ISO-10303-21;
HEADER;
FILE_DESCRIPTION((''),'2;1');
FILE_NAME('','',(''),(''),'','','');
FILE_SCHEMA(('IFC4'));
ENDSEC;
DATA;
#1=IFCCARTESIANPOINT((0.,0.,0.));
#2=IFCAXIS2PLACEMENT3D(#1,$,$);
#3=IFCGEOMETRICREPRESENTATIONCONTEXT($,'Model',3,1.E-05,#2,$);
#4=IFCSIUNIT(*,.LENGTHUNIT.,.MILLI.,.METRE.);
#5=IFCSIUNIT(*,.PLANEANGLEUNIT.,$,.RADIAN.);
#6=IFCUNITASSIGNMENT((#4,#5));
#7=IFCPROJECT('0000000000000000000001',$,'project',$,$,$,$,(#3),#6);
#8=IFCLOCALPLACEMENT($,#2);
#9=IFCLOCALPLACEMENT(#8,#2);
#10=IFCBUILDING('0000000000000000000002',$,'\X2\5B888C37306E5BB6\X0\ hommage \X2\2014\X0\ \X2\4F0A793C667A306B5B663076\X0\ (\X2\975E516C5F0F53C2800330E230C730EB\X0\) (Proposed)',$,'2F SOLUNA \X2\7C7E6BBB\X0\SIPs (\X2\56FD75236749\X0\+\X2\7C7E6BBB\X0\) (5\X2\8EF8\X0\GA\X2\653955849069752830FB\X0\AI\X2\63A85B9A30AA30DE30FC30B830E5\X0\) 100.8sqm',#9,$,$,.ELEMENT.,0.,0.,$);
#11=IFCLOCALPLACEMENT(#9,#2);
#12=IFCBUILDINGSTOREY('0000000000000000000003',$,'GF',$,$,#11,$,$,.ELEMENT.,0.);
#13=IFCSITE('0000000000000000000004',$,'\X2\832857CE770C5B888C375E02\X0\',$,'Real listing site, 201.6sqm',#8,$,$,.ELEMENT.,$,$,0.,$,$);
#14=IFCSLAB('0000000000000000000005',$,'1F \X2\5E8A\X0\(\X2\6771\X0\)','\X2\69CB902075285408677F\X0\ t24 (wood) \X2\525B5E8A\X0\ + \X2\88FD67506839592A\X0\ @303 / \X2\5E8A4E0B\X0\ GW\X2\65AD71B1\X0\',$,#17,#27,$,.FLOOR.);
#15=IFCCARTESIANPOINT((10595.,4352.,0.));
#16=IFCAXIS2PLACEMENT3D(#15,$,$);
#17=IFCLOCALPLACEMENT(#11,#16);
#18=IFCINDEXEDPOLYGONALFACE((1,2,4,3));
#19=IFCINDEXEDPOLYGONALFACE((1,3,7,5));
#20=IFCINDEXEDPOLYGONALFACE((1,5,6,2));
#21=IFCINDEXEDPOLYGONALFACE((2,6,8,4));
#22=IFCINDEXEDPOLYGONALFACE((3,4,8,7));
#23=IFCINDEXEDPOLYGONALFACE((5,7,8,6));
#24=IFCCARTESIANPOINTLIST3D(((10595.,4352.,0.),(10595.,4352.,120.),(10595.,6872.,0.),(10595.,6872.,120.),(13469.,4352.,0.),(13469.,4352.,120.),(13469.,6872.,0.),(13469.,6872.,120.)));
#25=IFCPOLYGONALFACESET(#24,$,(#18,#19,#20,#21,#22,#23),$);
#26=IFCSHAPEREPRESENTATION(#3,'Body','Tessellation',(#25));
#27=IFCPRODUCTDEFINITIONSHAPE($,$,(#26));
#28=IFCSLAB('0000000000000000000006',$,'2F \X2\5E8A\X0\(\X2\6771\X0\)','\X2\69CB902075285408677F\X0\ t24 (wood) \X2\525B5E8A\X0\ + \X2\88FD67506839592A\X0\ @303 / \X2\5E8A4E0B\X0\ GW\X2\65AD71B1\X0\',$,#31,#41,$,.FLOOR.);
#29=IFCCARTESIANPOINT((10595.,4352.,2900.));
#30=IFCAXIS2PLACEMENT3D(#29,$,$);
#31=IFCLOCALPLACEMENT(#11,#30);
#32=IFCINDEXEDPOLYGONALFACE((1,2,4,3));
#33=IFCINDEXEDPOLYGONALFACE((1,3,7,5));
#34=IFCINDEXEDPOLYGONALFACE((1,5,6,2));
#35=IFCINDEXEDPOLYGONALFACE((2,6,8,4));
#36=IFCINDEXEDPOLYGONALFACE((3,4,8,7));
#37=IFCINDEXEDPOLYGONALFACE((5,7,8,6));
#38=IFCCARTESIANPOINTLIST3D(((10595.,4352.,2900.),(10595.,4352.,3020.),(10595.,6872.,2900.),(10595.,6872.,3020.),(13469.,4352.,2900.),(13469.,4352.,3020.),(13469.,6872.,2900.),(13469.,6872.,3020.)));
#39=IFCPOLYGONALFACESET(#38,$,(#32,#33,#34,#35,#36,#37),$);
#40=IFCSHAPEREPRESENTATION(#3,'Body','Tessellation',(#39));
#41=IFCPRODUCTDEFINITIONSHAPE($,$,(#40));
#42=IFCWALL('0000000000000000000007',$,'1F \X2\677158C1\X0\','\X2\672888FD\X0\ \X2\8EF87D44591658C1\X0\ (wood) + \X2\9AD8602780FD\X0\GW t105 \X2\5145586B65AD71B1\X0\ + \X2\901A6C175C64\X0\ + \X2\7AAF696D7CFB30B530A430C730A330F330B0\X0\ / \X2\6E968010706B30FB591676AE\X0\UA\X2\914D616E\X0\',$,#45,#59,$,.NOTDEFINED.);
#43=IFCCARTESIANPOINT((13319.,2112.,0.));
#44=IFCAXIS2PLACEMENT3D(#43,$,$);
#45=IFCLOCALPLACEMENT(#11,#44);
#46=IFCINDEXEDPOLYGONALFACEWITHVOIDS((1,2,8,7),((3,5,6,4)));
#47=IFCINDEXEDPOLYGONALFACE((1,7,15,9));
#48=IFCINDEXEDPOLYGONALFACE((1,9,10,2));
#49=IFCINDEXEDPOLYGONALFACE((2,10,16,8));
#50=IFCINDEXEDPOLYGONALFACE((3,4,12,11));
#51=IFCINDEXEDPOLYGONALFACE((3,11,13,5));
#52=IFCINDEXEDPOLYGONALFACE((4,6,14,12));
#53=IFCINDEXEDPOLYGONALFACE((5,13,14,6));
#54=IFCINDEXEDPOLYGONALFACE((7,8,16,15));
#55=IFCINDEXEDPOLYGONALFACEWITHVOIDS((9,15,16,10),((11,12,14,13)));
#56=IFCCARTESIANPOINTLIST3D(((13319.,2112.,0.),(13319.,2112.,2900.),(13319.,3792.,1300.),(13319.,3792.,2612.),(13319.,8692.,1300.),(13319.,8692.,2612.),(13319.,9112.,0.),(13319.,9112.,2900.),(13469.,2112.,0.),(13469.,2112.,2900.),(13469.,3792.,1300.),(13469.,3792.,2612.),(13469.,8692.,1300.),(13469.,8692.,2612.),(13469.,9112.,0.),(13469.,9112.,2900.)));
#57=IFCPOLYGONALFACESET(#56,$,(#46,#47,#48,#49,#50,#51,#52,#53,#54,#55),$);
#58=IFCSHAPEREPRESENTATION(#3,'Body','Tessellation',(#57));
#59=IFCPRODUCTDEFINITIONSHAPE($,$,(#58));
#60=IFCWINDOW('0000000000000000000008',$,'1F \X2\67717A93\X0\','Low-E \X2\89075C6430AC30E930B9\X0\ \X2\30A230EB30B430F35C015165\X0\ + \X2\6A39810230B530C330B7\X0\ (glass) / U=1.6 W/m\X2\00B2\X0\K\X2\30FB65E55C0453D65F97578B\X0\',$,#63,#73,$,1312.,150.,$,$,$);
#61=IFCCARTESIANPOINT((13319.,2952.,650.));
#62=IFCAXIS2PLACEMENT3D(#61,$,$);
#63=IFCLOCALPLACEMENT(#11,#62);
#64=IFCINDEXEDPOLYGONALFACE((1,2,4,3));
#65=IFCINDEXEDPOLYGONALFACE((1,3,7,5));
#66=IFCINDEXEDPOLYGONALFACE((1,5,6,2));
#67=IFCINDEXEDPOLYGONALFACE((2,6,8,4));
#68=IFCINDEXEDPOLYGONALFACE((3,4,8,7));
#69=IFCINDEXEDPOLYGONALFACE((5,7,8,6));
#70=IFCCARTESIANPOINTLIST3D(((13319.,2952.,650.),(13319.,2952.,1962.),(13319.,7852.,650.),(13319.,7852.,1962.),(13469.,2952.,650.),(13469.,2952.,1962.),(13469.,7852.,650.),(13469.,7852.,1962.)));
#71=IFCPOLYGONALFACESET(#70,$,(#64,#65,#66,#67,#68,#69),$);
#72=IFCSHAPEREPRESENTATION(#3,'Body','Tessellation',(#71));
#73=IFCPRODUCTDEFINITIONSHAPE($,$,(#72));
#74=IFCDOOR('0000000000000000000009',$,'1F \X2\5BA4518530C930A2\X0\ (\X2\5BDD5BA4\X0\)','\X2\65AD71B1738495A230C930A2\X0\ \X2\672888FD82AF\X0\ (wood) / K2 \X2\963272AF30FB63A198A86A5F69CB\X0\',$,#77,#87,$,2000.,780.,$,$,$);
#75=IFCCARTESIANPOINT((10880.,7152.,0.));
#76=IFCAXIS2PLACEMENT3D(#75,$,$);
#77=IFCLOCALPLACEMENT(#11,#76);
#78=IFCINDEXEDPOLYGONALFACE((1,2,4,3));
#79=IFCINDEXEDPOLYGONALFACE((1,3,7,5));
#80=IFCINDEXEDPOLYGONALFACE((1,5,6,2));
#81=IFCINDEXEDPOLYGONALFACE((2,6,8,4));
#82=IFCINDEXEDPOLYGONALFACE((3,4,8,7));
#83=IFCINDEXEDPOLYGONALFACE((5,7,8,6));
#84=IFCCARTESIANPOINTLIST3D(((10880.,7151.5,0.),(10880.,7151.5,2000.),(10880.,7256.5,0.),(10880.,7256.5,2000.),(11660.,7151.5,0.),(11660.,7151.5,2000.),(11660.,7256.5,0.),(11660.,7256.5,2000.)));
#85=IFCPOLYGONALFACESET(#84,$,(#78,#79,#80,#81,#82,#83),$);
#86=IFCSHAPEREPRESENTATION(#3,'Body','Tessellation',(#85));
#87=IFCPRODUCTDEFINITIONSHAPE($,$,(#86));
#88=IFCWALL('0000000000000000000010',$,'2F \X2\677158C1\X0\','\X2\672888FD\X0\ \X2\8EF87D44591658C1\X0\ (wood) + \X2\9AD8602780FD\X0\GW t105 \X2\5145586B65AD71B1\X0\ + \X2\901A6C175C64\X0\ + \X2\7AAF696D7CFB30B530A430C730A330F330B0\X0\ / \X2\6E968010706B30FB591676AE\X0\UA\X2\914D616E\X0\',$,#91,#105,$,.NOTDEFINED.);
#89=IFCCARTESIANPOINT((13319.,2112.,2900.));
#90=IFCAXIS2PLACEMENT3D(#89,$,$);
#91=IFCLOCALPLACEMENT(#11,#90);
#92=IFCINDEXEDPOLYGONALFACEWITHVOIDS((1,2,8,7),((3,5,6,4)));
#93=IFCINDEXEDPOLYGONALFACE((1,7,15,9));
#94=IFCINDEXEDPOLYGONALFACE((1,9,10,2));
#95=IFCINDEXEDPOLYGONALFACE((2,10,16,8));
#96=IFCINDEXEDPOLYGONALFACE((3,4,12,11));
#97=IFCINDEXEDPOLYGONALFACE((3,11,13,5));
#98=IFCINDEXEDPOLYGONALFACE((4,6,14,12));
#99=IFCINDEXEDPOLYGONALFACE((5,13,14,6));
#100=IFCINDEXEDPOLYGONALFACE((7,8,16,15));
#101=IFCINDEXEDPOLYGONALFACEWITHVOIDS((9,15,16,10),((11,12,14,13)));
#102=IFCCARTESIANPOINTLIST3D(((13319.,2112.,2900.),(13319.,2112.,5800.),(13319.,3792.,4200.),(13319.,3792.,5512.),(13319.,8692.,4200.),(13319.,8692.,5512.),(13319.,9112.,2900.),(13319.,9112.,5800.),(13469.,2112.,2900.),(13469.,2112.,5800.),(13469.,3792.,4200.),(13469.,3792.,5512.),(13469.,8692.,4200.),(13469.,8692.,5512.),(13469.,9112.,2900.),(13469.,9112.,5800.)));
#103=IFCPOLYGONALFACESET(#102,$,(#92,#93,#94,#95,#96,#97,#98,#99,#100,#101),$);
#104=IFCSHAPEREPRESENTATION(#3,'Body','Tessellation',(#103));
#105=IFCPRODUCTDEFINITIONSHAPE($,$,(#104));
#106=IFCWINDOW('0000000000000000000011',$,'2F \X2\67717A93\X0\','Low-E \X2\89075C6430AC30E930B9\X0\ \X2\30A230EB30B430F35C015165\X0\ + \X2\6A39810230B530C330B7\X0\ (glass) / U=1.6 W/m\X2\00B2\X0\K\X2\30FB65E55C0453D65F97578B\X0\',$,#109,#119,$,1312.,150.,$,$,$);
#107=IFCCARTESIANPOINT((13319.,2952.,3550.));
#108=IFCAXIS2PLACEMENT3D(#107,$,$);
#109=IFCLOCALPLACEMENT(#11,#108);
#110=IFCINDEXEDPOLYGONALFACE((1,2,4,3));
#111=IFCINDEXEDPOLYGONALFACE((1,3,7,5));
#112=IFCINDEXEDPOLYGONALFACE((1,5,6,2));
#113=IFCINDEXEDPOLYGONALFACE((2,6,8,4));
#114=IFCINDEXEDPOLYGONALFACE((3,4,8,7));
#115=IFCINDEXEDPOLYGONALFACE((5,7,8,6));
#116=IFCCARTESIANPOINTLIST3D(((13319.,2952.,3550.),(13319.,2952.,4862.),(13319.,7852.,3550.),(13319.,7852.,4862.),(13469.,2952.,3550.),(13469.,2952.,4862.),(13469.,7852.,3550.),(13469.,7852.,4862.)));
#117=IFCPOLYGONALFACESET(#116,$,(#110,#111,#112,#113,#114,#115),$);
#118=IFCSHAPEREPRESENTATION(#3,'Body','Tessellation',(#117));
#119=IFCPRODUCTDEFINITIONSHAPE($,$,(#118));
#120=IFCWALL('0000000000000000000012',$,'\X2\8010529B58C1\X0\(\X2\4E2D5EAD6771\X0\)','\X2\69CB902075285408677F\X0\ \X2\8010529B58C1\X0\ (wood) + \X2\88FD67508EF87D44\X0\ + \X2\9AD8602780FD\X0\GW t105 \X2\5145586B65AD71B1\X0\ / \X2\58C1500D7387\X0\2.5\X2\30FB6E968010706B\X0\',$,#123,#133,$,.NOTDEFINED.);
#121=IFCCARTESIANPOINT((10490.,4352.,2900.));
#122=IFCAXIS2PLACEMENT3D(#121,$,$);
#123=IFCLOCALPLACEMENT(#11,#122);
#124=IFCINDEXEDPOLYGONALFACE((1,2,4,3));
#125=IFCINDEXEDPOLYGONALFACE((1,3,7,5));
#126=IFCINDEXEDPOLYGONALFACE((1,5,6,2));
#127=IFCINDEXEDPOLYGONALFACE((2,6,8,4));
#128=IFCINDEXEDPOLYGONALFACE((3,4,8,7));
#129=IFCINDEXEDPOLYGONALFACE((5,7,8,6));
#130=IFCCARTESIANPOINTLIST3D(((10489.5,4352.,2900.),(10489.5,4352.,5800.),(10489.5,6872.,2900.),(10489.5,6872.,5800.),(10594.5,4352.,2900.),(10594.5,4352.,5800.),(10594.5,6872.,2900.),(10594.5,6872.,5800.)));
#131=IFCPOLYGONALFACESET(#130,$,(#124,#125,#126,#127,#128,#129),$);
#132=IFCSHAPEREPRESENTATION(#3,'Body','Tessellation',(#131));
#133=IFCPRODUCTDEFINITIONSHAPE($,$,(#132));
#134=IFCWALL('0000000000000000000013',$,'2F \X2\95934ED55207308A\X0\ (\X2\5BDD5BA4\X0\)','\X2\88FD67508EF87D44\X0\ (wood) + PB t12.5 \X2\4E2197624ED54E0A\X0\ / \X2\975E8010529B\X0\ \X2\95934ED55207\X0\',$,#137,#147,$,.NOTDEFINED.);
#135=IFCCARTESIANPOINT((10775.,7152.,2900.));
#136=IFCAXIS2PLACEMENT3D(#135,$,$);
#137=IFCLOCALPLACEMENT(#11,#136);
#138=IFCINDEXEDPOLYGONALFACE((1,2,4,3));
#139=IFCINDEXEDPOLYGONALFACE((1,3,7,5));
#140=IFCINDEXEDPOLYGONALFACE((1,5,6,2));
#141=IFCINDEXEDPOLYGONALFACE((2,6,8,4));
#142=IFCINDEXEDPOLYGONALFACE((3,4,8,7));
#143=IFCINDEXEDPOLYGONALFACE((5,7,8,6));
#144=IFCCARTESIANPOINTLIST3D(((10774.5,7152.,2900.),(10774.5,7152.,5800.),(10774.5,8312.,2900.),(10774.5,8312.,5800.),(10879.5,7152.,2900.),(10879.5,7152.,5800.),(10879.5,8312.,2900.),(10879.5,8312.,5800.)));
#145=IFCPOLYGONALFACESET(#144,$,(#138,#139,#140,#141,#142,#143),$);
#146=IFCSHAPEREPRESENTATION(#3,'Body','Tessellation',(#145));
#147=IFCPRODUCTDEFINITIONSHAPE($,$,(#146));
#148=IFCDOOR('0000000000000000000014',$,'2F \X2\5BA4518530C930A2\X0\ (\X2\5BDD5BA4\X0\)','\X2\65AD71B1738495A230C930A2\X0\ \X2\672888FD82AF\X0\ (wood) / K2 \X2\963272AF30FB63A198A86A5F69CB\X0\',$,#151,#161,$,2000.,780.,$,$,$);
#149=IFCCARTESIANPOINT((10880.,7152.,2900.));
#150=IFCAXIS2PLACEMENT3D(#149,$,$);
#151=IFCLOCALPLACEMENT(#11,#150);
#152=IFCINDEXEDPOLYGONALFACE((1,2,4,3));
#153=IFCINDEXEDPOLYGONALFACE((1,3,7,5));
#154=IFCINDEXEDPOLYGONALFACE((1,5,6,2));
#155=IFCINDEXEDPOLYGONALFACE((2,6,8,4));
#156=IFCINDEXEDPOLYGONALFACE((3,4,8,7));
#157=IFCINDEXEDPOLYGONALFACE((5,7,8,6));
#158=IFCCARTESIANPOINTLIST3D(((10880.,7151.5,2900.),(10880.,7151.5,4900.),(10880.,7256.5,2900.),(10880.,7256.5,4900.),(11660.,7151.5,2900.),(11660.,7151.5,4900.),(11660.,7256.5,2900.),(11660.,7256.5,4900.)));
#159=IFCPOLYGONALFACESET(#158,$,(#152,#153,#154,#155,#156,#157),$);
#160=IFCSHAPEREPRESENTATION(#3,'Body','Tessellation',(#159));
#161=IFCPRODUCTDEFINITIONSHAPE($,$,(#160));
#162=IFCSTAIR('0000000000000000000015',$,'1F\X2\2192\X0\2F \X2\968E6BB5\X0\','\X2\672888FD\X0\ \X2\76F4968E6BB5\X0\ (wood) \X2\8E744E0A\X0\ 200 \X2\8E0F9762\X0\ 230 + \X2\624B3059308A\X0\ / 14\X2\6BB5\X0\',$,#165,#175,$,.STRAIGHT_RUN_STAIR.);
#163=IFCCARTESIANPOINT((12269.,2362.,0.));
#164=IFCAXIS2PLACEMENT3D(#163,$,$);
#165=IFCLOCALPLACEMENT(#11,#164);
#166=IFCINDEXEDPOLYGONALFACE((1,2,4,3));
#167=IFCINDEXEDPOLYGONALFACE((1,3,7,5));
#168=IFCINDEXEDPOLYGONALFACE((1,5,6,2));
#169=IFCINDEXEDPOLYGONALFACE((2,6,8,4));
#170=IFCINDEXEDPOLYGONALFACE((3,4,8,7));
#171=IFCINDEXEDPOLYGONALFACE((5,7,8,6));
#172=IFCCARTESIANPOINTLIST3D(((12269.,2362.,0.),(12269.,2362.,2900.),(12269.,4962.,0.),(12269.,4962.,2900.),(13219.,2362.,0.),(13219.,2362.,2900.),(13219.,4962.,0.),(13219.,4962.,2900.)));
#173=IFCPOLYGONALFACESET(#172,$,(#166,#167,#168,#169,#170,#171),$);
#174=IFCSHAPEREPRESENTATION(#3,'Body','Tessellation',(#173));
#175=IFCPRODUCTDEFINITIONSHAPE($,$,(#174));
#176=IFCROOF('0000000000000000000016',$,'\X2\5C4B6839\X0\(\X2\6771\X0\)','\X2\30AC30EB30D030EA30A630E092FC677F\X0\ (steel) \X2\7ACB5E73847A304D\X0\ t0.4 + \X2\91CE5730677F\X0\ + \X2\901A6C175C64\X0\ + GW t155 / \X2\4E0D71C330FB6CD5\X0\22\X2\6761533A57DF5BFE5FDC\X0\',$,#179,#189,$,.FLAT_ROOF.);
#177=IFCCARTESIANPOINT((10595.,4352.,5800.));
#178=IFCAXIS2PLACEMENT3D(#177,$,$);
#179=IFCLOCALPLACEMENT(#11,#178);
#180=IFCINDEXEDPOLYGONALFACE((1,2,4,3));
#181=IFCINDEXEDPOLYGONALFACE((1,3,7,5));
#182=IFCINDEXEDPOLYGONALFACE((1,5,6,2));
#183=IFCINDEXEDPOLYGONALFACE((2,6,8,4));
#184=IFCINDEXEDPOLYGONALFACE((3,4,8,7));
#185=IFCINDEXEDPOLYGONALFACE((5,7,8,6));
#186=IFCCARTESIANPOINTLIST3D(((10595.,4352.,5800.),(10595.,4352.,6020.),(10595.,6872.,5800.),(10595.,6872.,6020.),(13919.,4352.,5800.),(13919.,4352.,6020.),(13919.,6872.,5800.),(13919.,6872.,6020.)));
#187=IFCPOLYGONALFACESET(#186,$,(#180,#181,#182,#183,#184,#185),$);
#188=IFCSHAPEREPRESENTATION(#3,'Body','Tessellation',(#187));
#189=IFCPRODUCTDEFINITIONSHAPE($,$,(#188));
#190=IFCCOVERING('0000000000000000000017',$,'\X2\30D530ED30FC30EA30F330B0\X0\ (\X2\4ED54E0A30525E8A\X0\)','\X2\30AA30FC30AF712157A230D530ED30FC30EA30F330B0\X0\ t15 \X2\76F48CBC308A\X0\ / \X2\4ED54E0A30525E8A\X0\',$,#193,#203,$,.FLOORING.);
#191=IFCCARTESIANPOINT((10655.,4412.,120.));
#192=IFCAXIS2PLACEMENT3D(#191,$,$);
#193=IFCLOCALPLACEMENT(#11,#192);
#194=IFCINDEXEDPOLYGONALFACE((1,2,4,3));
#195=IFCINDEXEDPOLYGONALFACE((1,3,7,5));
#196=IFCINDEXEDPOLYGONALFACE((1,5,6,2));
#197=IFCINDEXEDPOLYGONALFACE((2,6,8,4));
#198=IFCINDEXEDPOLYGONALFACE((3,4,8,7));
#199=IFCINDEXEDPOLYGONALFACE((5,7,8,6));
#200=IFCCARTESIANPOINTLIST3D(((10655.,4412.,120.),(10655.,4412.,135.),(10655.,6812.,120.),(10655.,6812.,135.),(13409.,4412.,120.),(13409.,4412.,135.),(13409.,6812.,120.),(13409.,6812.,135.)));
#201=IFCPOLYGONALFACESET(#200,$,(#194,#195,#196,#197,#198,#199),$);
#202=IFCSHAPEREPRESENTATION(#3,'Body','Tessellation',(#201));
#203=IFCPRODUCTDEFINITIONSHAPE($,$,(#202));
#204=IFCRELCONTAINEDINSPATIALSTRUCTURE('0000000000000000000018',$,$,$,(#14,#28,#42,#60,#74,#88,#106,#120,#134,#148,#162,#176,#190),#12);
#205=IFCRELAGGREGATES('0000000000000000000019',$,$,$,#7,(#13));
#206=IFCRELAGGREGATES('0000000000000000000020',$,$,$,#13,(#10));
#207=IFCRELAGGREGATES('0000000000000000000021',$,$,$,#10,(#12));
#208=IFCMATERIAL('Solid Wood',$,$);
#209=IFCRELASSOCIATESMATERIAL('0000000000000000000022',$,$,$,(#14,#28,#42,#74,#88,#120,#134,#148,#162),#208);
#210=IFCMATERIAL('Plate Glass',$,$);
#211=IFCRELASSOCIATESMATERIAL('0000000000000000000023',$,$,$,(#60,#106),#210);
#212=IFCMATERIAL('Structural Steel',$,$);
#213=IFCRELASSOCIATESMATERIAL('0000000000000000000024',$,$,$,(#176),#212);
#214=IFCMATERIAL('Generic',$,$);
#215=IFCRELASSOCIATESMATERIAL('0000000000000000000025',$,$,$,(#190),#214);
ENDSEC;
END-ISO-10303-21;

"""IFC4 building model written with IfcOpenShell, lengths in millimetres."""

from ifc_helpers import new_model, si_unit, frame, frame_2d, origin, place, context, project, spatial, rectangle, extrude, material, element, fill, save


model = new_model("IFC4")

# Units and contexts
model_context = context("Model", 3, precision=1e-05, world=origin())
ifc_project = project(units=[si_unit("LENGTHUNIT", "METRE", prefix="MILLI"), si_unit("PLANEANGLEUNIT", "RADIAN")], contexts=[model_context])

# Site, building, storey
site_placement = place(None, origin())
site = spatial("IfcSite", under=ifc_project, at=site_placement, Name="茨城県守谷市", ObjectType="Real listing site, 201.6sqm", CompositionType="ELEMENT", RefElevation=0.0)
building_placement = place(site_placement, origin())
building = spatial("IfcBuilding", under=site, at=building_placement, Name="守谷の家 hommage — 伊礼智に学ぶ (非公式参考モデル) (Proposed)", ObjectType="2F SOLUNA 籾殻SIPs (国産杉+籾殻) (5軸GA改善適用・AI推定オマージュ) 100.8sqm", CompositionType="ELEMENT", ElevationOfRefHeight=0.0, ElevationOfTerrain=0.0)
storey_placement = place(building_placement, origin())
storey = spatial("IfcBuildingStorey", under=building, at=storey_placement, Name="GF", CompositionType="ELEMENT", Elevation=0.0)

# Slabs
ifc_material_1 = material(Name="Solid Wood")
slab_1_placement = place(storey_placement, frame((10595.0, 4352.0, 0.0)))
element("IfcSlab", 1, at=slab_1_placement, inside=storey, material=ifc_material_1, Name="1F 床(東)", Description="構造用合板 t24 (wood) 剛床 + 製材根太 @303 / 床下 GW断熱", PredefinedType="FLOOR", context=model_context, shape_type="SweptSolid", body=[
    extrude(rectangle(XDim=2874.0, YDim=2520.0, at=frame_2d((1437.0, 1260.0))), frame((10595.0, 4352.0, 0.0)), (0.0, 0.0, 1.0), 120.0),
])
slab_2_placement = place(storey_placement, frame((10595.0, 4352.0, 2900.0)))
element("IfcSlab", 2, at=slab_2_placement, inside=storey, material=ifc_material_1, Name="2F 床(東)", Description="構造用合板 t24 (wood) 剛床 + 製材根太 @303 / 床下 GW断熱", PredefinedType="FLOOR", context=model_context, shape_type="SweptSolid", body=[
    extrude(rectangle(XDim=2874.0, YDim=2520.0, at=frame_2d((1437.0, 1260.0))), frame((10595.0, 4352.0, 2900.0)), (0.0, 0.0, 1.0), 120.0),
])

# Wall, opening, window
wall_1_placement = place(storey_placement, frame((13319.0, 2112.0, 0.0)))
wall_1 = element("IfcWall", 3, at=wall_1_placement, inside=storey, material=ifc_material_1, Name="1F 東壁", Description="木製 軸組外壁 (wood) + 高性能GW t105 充填断熱 + 通気層 + 窯業系サイディング / 準耐火・外皮UA配慮", PredefinedType="NOTDEFINED", context=model_context, shape_type="SweptSolid", body=[
    extrude(rectangle(XDim=150.0, YDim=7000.0, at=frame_2d((75.0, 3500.0))), frame((13319.0, 2112.0, 0.0)), (0.0, 0.0, 1.0), 2900.0),
])
opening_1_placement = place(storey_placement, frame((13319.0, 2952.0, 650.0)))
opening_1 = element("IfcOpeningElement", 4, at=opening_1_placement, cuts=wall_1, PredefinedType="NOTDEFINED", context=model_context, shape_type="SweptSolid", body=[
    extrude(rectangle(XDim=150.0, YDim=4900.0, at=frame_2d((75.0, 2450.0))), frame((13319.0, 2952.0, 650.0)), (0.0, 0.0, 1.0), 1312.0),
])
ifc_material_2 = material(Name="Plate Glass")
window_1_placement = place(storey_placement, frame((13319.0, 2952.0, 650.0)))
window_1 = element("IfcWindow", 5, at=window_1_placement, inside=storey, material=ifc_material_2, Name="1F 東窓", Description="Low-E 複層ガラス アルゴン封入 + 樹脂サッシ (glass) / U=1.6 W/m²K・日射取得型", OverallHeight=1312.0, OverallWidth=150.0, context=model_context, shape_type="SweptSolid", body=[
    extrude(rectangle(XDim=150.0, YDim=4900.0, at=frame_2d((75.0, 2450.0))), frame((13319.0, 2952.0, 650.0)), (0.0, 0.0, 1.0), 1312.0),
])
fill(opening_1, window_1)

# Door
door_1_placement = place(storey_placement, frame((10880.0, 7152.0, 0.0)))
element("IfcDoor", 6, at=door_1_placement, inside=storey, material=ifc_material_1, Name="1F 室内ドア (寝室)", Description="断熱玄関ドア 木製芯 (wood) / K2 防犯・採風機構", OverallHeight=2000.0, OverallWidth=780.0, context=model_context, shape_type="SweptSolid", body=[
    extrude(rectangle(XDim=780.0, YDim=105.0, at=frame_2d((390.0, 52.0))), frame((10880.0, 7152.0, 0.0)), (0.0, 0.0, 1.0), 2000.0),
])

# Wall, opening, window
wall_2_placement = place(storey_placement, frame((13319.0, 2112.0, 2900.0)))
wall_2 = element("IfcWall", 7, at=wall_2_placement, inside=storey, material=ifc_material_1, Name="2F 東壁", Description="木製 軸組外壁 (wood) + 高性能GW t105 充填断熱 + 通気層 + 窯業系サイディング / 準耐火・外皮UA配慮", PredefinedType="NOTDEFINED", context=model_context, shape_type="SweptSolid", body=[
    extrude(rectangle(XDim=150.0, YDim=7000.0, at=frame_2d((75.0, 3500.0))), frame((13319.0, 2112.0, 2900.0)), (0.0, 0.0, 1.0), 2900.0),
])
opening_2_placement = place(storey_placement, frame((13319.0, 2952.0, 3550.0)))
opening_2 = element("IfcOpeningElement", 8, at=opening_2_placement, cuts=wall_2, PredefinedType="NOTDEFINED", context=model_context, shape_type="SweptSolid", body=[
    extrude(rectangle(XDim=150.0, YDim=4900.0, at=frame_2d((75.0, 2450.0))), frame((13319.0, 2952.0, 3550.0)), (0.0, 0.0, 1.0), 1312.0),
])
window_2_placement = place(storey_placement, frame((13319.0, 2952.0, 3550.0)))
window_2 = element("IfcWindow", 9, at=window_2_placement, inside=storey, material=ifc_material_2, Name="2F 東窓", Description="Low-E 複層ガラス アルゴン封入 + 樹脂サッシ (glass) / U=1.6 W/m²K・日射取得型", OverallHeight=1312.0, OverallWidth=150.0, context=model_context, shape_type="SweptSolid", body=[
    extrude(rectangle(XDim=150.0, YDim=4900.0, at=frame_2d((75.0, 2450.0))), frame((13319.0, 2952.0, 3550.0)), (0.0, 0.0, 1.0), 1312.0),
])
fill(opening_2, window_2)

# Walls
wall_3_placement = place(storey_placement, frame((10490.0, 4352.0, 2900.0)))
element("IfcWall", 10, at=wall_3_placement, inside=storey, material=ifc_material_1, Name="耐力壁(中庭東)", Description="構造用合板 耐力壁 (wood) + 製材軸組 + 高性能GW t105 充填断熱 / 壁倍率2.5・準耐火", PredefinedType="NOTDEFINED", context=model_context, shape_type="SweptSolid", body=[
    extrude(rectangle(XDim=105.0, YDim=2520.0, at=frame_2d((52.0, 1260.0))), frame((10490.0, 4352.0, 2900.0)), (0.0, 0.0, 1.0), 2900.0),
])
wall_4_placement = place(storey_placement, frame((10775.0, 7152.0, 2900.0)))
element("IfcWall", 11, at=wall_4_placement, inside=storey, material=ifc_material_1, Name="2F 間仕切り (寝室)", Description="製材軸組 (wood) + PB t12.5 両面仕上 / 非耐力 間仕切", PredefinedType="NOTDEFINED", context=model_context, shape_type="SweptSolid", body=[
    extrude(rectangle(XDim=105.0, YDim=1160.0, at=frame_2d((52.0, 580.0))), frame((10775.0, 7152.0, 2900.0)), (0.0, 0.0, 1.0), 2900.0),
])

# Door
door_2_placement = place(storey_placement, frame((10880.0, 7152.0, 2900.0)))
element("IfcDoor", 12, at=door_2_placement, inside=storey, material=ifc_material_1, Name="2F 室内ドア (寝室)", Description="断熱玄関ドア 木製芯 (wood) / K2 防犯・採風機構", OverallHeight=2000.0, OverallWidth=780.0, context=model_context, shape_type="SweptSolid", body=[
    extrude(rectangle(XDim=780.0, YDim=105.0, at=frame_2d((390.0, 52.0))), frame((10880.0, 7152.0, 2900.0)), (0.0, 0.0, 1.0), 2000.0),
])

# Stair
stair_placement = place(storey_placement, frame((12269.0, 2362.0, 0.0)))
element("IfcStair", 13, at=stair_placement, inside=storey, material=ifc_material_1, Name="1F→2F 階段", Description="木製 直階段 (wood) 蹴上 200 踏面 230 + 手すり / 14段", PredefinedType="STRAIGHT_RUN_STAIR", context=model_context, shape_type="SweptSolid", body=[
    extrude(rectangle(XDim=950.0, YDim=2600.0, at=frame_2d((475.0, 1300.0))), frame((12269.0, 2362.0, 0.0)), (0.0, 0.0, 1.0), 2900.0),
])

# Roof
ifc_material_3 = material(Name="Structural Steel")
for number, where, name in (
    (14, (10595.0, 4352.0, 5800.0), "屋根(東)"),
):
    element("IfcRoof", number, at=place(storey_placement, frame(where)), inside=storey, material=ifc_material_3, Name=name, Description="ガルバリウム鋼板 (steel) 立平葺き t0.4 + 野地板 + 通気層 + GW t155 / 不燃・法22条区域対応", PredefinedType="FLAT_ROOF", context=model_context, shape_type="SweptSolid", body=[
        extrude(rectangle(XDim=3324.0, YDim=2520.0, at=frame_2d((1662.0, 1260.0))), frame((10595.0, 4352.0, 5800.0)), (0.0, 0.0, 1.0), 220.0),
    ])

# Covering
ifc_material_4 = material(Name="Generic")
covering_1_placement = place(storey_placement, frame((10655.0, 4412.0, 120.0)))
element("IfcCovering", 15, at=covering_1_placement, inside=storey, material=ifc_material_4, Name="フローリング (仕上げ床)", Description="オーク無垢フローリング t15 直貼り / 仕上げ床", PredefinedType="FLOORING", context=model_context, shape_type="SweptSolid", body=[
    extrude(rectangle(XDim=2754.0, YDim=2400.0, at=frame_2d((1377.0, 1200.0))), frame((10655.0, 4412.0, 120.0)), (0.0, 0.0, 1.0), 15.0),
])

save(model, "model.ifc")
